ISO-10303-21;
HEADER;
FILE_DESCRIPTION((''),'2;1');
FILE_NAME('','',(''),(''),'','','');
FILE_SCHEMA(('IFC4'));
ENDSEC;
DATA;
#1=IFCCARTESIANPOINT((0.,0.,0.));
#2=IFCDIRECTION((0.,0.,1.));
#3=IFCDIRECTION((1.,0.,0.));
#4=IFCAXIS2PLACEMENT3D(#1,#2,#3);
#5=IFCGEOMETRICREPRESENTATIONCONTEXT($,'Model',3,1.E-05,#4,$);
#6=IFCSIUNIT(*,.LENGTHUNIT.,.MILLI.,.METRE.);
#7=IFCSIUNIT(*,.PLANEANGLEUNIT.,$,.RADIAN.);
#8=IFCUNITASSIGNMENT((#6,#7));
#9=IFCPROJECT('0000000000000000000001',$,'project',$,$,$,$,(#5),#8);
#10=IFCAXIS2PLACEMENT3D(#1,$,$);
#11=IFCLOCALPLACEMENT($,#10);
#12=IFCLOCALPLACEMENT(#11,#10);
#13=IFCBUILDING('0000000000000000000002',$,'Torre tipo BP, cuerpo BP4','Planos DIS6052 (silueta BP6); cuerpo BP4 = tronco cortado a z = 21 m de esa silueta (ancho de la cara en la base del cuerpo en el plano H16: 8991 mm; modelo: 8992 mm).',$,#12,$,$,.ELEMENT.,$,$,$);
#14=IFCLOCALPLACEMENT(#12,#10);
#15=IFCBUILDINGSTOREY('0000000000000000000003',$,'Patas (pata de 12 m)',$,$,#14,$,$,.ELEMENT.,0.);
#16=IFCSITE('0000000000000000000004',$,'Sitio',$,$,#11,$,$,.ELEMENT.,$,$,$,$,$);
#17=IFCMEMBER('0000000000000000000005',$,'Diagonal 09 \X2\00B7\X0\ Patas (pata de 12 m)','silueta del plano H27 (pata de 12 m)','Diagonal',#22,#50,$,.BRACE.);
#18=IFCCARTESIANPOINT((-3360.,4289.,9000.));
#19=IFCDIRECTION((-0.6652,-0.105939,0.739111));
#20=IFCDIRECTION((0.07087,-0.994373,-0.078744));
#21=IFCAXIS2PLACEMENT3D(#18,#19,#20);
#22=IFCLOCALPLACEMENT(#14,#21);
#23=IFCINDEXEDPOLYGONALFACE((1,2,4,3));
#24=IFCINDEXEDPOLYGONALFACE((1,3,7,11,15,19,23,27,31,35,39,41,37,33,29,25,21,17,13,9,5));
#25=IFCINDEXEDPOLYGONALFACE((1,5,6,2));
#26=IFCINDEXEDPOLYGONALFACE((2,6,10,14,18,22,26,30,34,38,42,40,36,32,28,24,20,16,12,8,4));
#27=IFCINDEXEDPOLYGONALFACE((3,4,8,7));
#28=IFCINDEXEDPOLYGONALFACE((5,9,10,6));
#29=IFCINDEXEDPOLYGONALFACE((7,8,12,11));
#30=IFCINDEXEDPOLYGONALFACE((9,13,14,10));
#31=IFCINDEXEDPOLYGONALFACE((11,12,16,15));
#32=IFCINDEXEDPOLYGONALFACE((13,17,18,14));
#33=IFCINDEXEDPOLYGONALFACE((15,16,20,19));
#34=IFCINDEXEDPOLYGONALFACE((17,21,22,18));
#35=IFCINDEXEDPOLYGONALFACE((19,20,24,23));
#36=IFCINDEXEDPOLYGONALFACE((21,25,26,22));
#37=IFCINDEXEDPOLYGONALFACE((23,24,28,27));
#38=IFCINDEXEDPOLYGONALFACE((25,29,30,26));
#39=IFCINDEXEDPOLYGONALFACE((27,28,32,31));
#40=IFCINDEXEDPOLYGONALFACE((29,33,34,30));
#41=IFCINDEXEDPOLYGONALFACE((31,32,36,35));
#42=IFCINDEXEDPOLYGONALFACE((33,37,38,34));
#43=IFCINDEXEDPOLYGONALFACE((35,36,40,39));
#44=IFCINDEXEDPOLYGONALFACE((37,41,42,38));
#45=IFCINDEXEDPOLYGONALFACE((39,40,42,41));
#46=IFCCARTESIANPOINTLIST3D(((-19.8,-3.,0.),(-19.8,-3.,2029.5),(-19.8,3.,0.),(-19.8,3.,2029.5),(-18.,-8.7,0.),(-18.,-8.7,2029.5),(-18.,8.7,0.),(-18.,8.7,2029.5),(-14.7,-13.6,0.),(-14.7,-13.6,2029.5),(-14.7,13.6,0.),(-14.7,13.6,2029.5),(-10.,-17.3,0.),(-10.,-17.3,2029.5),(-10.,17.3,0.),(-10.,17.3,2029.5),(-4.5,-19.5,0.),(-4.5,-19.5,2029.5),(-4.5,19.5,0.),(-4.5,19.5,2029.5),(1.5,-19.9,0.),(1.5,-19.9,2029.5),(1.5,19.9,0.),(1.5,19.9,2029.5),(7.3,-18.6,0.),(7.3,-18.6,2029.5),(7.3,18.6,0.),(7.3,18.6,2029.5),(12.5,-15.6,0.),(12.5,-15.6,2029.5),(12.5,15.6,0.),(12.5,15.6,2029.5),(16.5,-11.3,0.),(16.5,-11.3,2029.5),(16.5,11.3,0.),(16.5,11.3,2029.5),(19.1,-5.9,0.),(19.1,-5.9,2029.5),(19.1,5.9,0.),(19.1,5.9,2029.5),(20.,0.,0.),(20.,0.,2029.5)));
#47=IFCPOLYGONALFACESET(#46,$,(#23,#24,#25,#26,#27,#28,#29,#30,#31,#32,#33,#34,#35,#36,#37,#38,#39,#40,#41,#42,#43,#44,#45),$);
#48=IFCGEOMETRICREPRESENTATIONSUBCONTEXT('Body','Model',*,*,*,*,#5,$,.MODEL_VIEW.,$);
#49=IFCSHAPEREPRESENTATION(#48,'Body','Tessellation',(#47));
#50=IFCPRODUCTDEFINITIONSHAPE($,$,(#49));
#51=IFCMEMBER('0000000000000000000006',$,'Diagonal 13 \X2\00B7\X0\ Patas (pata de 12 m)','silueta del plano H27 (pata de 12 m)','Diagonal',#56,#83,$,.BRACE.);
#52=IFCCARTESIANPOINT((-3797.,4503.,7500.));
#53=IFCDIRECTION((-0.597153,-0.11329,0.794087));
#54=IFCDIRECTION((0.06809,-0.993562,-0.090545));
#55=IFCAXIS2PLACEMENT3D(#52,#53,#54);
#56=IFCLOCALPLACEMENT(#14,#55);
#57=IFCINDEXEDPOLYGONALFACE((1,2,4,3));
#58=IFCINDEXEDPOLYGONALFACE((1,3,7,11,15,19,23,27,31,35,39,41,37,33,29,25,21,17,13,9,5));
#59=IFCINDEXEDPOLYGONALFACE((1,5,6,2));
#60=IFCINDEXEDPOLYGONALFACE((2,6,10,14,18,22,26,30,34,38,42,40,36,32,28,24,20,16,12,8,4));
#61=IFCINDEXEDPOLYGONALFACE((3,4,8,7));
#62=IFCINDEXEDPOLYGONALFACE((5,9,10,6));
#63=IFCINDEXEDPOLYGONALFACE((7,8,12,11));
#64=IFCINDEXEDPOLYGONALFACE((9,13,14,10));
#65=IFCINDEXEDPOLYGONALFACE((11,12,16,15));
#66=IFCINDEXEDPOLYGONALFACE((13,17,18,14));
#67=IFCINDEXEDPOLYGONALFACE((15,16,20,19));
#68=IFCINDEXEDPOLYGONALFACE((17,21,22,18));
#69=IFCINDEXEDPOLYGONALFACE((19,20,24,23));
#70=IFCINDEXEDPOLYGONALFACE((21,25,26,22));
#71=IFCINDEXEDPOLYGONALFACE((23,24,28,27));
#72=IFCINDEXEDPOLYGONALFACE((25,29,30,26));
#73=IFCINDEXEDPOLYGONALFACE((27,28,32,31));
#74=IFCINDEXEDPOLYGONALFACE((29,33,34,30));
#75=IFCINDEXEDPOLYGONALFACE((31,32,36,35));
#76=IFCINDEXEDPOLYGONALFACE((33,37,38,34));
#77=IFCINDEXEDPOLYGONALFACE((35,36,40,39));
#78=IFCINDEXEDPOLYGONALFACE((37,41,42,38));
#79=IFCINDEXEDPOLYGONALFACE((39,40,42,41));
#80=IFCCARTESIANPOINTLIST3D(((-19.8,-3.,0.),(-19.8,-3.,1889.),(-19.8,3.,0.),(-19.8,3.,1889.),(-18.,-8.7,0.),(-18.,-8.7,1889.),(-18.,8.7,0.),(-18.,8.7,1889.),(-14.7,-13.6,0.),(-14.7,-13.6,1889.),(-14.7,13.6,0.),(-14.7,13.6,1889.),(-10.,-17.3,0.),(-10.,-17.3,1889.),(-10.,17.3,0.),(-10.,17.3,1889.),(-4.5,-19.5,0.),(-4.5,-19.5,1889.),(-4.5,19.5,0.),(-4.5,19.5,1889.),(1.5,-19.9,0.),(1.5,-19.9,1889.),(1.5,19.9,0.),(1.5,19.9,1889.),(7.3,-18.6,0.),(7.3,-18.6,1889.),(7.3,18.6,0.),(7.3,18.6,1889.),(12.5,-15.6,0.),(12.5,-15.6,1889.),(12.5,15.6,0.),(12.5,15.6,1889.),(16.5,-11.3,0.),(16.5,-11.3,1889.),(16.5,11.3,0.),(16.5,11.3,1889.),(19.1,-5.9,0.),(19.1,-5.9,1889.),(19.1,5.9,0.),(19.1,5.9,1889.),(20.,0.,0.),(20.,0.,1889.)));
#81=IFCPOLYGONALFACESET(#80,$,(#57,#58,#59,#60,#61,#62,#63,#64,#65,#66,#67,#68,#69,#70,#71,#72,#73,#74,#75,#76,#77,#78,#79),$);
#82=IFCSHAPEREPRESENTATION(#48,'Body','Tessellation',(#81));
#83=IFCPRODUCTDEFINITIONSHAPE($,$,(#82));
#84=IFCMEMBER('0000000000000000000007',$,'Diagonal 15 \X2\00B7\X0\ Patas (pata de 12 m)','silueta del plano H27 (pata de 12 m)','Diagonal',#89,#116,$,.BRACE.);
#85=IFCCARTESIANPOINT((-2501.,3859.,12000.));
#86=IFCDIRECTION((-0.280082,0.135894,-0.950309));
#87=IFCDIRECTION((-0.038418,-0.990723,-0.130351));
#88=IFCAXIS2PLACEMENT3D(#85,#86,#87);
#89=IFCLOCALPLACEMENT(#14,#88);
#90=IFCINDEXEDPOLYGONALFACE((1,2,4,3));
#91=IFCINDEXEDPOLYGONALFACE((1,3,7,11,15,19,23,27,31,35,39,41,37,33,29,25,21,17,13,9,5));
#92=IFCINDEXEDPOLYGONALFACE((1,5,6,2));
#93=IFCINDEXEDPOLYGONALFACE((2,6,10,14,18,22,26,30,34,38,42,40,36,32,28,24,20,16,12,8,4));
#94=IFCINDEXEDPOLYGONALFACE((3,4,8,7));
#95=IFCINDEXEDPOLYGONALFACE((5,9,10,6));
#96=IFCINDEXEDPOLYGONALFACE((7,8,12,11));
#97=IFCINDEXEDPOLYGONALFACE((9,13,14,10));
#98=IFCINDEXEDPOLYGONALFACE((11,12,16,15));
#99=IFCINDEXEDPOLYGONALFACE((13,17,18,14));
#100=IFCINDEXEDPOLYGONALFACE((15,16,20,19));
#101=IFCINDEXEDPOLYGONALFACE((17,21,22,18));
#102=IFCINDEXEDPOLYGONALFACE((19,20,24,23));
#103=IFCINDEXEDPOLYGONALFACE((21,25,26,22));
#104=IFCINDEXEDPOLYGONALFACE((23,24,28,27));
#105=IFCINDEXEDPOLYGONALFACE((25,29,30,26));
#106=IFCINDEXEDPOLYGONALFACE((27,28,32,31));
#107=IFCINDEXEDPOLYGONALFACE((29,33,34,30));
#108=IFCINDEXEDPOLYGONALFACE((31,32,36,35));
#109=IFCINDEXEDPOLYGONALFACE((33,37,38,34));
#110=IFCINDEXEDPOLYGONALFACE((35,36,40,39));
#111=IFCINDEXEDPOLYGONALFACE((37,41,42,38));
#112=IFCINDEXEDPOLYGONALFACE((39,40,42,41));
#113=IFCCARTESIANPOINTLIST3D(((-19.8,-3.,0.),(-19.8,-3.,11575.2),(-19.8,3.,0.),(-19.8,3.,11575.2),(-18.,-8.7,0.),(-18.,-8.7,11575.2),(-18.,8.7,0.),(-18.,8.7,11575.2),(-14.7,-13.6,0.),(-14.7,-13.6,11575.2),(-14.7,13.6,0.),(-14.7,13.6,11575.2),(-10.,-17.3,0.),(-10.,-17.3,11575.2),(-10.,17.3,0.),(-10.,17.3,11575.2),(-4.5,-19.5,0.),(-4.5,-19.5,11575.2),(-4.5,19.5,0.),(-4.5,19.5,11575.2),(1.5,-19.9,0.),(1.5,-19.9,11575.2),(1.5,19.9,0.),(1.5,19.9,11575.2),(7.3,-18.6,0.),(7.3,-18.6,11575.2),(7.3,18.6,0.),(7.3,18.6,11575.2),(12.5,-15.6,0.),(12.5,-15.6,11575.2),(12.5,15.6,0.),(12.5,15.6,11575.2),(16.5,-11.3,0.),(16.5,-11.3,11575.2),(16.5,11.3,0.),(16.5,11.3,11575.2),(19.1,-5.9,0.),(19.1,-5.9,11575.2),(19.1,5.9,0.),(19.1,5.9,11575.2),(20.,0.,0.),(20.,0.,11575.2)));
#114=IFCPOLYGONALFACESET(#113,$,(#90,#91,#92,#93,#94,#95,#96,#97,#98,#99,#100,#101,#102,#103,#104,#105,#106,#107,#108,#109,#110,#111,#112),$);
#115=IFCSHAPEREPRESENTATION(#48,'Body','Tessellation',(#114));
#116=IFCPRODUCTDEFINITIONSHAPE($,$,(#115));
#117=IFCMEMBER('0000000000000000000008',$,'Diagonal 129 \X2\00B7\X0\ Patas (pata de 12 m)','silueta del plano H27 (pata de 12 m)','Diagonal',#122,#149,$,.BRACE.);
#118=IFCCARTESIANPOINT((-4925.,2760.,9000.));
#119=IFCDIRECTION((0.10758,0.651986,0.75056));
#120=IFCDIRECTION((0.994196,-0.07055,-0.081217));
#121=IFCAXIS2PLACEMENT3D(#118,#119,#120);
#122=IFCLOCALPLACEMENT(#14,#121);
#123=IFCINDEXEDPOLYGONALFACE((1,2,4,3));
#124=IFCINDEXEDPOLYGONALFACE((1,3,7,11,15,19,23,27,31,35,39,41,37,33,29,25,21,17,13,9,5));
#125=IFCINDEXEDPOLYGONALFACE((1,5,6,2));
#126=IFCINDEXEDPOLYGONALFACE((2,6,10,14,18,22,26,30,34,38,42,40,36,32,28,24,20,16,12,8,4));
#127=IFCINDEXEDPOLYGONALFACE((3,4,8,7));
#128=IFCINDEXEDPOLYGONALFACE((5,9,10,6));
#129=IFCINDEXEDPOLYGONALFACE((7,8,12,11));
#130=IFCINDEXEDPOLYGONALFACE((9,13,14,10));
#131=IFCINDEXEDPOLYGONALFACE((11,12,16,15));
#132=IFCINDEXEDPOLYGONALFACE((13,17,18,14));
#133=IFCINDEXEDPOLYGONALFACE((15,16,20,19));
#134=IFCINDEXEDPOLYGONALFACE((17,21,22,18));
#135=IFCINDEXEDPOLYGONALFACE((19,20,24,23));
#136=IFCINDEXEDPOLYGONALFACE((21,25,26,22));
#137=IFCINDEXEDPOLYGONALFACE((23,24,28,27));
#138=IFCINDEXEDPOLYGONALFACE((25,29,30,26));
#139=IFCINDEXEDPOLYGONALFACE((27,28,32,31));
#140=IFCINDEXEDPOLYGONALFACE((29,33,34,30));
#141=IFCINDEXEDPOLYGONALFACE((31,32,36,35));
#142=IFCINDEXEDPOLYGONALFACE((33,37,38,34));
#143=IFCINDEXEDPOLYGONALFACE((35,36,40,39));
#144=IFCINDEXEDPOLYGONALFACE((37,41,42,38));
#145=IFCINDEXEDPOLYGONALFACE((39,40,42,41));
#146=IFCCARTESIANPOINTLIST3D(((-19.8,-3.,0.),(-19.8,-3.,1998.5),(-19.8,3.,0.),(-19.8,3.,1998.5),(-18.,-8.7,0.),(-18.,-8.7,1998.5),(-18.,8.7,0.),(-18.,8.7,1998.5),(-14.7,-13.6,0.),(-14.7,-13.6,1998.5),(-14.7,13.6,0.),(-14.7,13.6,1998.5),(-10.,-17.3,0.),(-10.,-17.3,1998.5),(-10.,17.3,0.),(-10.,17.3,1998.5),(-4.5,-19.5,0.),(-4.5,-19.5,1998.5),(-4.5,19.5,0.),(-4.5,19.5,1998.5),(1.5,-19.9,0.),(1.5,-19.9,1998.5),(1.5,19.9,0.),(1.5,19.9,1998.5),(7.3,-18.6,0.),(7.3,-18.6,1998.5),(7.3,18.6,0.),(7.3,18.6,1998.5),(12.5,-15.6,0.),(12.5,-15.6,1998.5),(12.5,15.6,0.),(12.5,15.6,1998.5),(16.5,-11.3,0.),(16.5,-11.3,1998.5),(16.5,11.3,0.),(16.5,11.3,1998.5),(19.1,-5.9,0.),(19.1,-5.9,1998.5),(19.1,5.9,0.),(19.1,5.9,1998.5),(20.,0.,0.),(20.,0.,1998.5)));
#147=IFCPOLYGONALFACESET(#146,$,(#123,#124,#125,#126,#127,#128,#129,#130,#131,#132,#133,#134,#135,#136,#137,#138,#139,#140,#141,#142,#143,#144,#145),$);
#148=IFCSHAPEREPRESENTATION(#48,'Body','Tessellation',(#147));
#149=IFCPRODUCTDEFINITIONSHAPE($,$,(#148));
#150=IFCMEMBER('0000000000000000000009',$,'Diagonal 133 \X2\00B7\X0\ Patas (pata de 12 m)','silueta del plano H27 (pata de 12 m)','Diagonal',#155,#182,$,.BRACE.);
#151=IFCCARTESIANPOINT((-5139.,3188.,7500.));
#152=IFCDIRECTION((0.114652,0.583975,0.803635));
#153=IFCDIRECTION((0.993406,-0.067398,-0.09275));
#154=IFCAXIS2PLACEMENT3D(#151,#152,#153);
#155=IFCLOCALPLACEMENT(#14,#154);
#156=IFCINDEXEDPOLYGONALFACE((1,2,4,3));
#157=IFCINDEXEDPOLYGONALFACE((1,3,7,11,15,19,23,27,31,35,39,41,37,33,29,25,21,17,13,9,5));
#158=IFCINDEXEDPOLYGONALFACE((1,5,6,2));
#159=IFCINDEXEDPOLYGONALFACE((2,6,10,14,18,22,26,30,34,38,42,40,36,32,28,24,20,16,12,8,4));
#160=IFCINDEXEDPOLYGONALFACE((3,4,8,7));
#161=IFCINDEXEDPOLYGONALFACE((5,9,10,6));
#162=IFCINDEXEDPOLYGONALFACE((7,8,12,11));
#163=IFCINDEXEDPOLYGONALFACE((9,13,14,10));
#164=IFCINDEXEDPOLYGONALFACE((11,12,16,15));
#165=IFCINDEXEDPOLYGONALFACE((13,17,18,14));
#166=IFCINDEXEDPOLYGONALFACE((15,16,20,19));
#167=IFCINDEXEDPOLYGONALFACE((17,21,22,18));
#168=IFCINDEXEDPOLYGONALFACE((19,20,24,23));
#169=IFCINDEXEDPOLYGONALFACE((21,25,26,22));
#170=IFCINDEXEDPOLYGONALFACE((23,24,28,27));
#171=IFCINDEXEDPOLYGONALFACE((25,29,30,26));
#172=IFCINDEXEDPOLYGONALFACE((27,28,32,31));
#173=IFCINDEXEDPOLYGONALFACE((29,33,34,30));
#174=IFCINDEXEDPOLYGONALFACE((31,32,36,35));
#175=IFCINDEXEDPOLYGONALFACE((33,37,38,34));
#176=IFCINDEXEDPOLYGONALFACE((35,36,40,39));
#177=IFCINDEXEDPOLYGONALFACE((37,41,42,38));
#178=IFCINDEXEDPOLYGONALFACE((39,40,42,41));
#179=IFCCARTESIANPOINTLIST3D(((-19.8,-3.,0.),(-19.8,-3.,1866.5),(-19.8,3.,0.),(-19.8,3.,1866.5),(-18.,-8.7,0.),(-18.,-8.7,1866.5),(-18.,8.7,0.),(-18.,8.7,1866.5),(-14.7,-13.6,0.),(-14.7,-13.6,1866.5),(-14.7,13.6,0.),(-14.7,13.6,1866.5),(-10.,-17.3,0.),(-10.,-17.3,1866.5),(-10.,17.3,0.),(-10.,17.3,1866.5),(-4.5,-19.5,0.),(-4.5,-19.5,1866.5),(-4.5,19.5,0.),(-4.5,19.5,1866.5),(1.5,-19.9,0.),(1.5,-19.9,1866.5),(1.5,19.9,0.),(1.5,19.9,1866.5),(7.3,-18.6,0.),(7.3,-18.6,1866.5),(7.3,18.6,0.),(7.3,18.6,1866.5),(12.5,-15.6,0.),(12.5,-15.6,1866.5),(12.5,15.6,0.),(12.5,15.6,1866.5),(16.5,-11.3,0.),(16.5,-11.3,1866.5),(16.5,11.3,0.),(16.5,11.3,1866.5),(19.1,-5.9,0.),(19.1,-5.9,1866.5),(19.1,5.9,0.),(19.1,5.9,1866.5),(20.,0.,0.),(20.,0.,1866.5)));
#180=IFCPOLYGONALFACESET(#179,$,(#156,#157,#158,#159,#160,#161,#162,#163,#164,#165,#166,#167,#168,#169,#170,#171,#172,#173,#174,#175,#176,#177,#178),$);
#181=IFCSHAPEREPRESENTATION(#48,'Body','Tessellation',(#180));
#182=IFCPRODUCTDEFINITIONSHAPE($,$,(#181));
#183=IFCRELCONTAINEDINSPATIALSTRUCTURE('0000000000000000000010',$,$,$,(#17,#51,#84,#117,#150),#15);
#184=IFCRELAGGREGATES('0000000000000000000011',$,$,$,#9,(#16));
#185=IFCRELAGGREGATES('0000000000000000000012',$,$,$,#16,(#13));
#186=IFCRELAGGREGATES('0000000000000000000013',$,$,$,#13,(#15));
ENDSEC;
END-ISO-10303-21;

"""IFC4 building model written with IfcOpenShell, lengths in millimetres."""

from ifc_helpers import new_model, si_unit, frame, origin, origin_with_axes, place, context, subcontext, project, spatial, circle, extrude, element, save


model = new_model("IFC4")

# Units and contexts
model_context = context("Model", 3, precision=1e-05, world=origin_with_axes())
body_context = subcontext(model_context, "Body", "Model", "MODEL_VIEW")
ifc_project = project(units=[si_unit("LENGTHUNIT", "METRE", prefix="MILLI"), si_unit("PLANEANGLEUNIT", "RADIAN")], contexts=[model_context])

# Site, building, storey
site_placement = place(None, origin())
site = spatial("IfcSite", under=ifc_project, at=site_placement, Name="Sitio", CompositionType="ELEMENT")
building_placement = place(site_placement, origin())
building = spatial("IfcBuilding", under=site, at=building_placement, Name="Torre tipo BP, cuerpo BP4", Description="Planos DIS6052 (silueta BP6); cuerpo BP4 = tronco cortado a z = 21 m de esa silueta (ancho de la cara en la base del cuerpo en el plano H16: 8991 mm; modelo: 8992 mm).", CompositionType="ELEMENT")
storey_placement = place(building_placement, origin())
storey = spatial("IfcBuildingStorey", under=building, at=storey_placement, Name="Patas (pata de 12 m)", CompositionType="ELEMENT", Elevation=0.0)

# Members
member_1_placement = place(storey_placement, frame((-3360.0, 4289.0, 9000.0), z_axis=(-0.6652, -0.105939, 0.739111), x_axis=(0.07087, -0.994373, -0.078744)))
element("IfcMember", 1, at=member_1_placement, inside=storey, Name="Diagonal 09 · Patas (pata de 12 m)", Description="silueta del plano H27 (pata de 12 m)", ObjectType="Diagonal", PredefinedType="BRACE", context=body_context, shape_type="SweptSolid", body=[
    extrude(circle(Radius=20.0), None, (0.0, 0.0, 1.0), 2029.5),
])
member_2_placement = place(storey_placement, frame((-3797.0, 4503.0, 7500.0), z_axis=(-0.597153, -0.11329, 0.794087), x_axis=(0.06809, -0.993562, -0.090545)))
element("IfcMember", 2, at=member_2_placement, inside=storey, Name="Diagonal 13 · Patas (pata de 12 m)", Description="silueta del plano H27 (pata de 12 m)", ObjectType="Diagonal", PredefinedType="BRACE", context=body_context, shape_type="SweptSolid", body=[
    extrude(circle(Radius=20.0), None, (0.0, 0.0, 1.0), 1889.0),
])
member_3_placement = place(storey_placement, frame((-2501.0, 3859.0, 12000.0), z_axis=(-0.280082, 0.135894, -0.950309), x_axis=(-0.038418, -0.990723, -0.130351)))
element("IfcMember", 3, at=member_3_placement, inside=storey, Name="Diagonal 15 · Patas (pata de 12 m)", Description="silueta del plano H27 (pata de 12 m)", ObjectType="Diagonal", PredefinedType="BRACE", context=body_context, shape_type="SweptSolid", body=[
    extrude(circle(Radius=20.0), None, (0.0, 0.0, 1.0), 11575.2),
])
member_4_placement = place(storey_placement, frame((-4925.0, 2760.0, 9000.0), z_axis=(0.10758, 0.651986, 0.75056), x_axis=(0.994196, -0.07055, -0.081217)))
element("IfcMember", 4, at=member_4_placement, inside=storey, Name="Diagonal 129 · Patas (pata de 12 m)", Description="silueta del plano H27 (pata de 12 m)", ObjectType="Diagonal", PredefinedType="BRACE", context=body_context, shape_type="SweptSolid", body=[
    extrude(circle(Radius=20.0), None, (0.0, 0.0, 1.0), 1998.5),
])
member_5_placement = place(storey_placement, frame((-5139.0, 3188.0, 7500.0), z_axis=(0.114652, 0.583975, 0.803635), x_axis=(0.993406, -0.067398, -0.09275)))
element("IfcMember", 5, at=member_5_placement, inside=storey, Name="Diagonal 133 · Patas (pata de 12 m)", Description="silueta del plano H27 (pata de 12 m)", ObjectType="Diagonal", PredefinedType="BRACE", context=body_context, shape_type="SweptSolid", body=[
    extrude(circle(Radius=20.0), None, (0.0, 0.0, 1.0), 1866.5),
])

save(model, "model.ifc")
